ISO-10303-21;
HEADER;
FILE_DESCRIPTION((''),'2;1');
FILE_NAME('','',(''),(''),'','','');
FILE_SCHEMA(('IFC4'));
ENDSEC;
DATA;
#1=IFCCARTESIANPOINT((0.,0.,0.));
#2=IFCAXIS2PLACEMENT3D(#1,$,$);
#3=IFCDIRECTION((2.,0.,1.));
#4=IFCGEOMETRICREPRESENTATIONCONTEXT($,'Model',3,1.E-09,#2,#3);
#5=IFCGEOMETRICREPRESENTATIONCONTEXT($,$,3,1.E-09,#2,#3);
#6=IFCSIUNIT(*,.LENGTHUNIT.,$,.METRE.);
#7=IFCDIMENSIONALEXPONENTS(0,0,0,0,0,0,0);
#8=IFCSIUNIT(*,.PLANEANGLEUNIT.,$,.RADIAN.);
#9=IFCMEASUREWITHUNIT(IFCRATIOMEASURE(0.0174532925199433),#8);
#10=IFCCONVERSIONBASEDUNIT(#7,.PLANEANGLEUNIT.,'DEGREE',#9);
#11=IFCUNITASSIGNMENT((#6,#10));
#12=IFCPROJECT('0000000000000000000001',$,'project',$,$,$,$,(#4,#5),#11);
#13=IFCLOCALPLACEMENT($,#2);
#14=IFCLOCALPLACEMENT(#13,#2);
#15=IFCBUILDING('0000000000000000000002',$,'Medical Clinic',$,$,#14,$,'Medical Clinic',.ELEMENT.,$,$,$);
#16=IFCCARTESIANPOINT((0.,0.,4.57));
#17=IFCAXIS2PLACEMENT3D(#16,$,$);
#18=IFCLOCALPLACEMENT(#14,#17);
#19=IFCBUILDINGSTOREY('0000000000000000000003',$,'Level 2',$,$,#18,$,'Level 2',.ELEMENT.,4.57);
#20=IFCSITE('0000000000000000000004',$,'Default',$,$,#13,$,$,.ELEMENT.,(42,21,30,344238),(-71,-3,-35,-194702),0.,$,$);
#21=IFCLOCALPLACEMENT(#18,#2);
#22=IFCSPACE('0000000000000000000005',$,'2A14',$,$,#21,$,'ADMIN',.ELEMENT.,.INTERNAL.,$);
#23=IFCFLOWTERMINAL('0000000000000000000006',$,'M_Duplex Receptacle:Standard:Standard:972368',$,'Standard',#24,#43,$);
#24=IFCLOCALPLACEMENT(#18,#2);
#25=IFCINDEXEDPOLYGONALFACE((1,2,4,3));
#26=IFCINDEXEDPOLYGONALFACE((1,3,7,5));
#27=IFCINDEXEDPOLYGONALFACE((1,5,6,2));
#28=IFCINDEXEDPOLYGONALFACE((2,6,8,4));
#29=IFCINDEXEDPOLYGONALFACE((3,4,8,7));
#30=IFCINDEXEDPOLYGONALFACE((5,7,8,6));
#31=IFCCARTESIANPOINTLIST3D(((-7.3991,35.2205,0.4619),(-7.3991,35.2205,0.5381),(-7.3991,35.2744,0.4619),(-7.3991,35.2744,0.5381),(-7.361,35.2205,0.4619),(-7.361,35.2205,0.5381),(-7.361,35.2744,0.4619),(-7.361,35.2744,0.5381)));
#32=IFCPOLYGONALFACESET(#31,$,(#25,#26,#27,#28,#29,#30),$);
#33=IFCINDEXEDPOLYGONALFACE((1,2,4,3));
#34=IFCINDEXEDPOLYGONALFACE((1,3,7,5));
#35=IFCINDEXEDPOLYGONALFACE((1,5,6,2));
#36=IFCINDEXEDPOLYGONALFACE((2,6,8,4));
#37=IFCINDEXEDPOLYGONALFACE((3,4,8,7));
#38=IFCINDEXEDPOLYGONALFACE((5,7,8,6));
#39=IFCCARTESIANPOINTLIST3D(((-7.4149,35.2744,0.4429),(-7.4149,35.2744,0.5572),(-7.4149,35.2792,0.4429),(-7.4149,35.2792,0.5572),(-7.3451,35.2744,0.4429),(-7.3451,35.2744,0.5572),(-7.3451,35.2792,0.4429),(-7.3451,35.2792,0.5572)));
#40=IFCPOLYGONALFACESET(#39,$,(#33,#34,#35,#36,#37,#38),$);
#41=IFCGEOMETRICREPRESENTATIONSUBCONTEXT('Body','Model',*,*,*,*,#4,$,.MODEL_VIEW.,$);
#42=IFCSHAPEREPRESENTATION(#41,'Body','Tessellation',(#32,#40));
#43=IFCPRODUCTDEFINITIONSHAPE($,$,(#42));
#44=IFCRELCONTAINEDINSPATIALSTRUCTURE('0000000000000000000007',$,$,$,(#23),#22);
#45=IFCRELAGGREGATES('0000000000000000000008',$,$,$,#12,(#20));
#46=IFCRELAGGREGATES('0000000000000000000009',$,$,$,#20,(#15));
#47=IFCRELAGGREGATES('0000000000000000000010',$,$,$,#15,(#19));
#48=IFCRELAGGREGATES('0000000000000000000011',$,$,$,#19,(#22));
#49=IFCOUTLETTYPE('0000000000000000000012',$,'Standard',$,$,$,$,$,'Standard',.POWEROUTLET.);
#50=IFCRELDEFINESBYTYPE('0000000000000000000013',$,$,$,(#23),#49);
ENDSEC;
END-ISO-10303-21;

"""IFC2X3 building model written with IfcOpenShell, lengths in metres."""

from ifc_helpers import new_model, entity, si_unit, converted_unit, direction, frame, frame_2d, origin, origin_2d_with_axis, place, context, subcontext, project, spatial, rectangle, extrude, source, transform, mapped, type_object, type_shapes, element, save


model = new_model("IFC2X3")

# Units and contexts
model_context = context("Model", 3, precision=1e-09, world=origin(), true_north=direction((2.0, 0.0, 1.0)))
context_of_model = context(None, 3, precision=1e-09, world=origin(), true_north=direction((2.0, 0.0, 1.0)))
body_context = subcontext(model_context, "Body", "Model", "MODEL_VIEW")
ifc_project = project(units=[si_unit("LENGTHUNIT", "METRE"), converted_unit("PLANEANGLEUNIT", "DEGREE", entity("IfcRatioMeasure", 0.0174532925199433), si_unit("PLANEANGLEUNIT", "RADIAN"), dimensions=[0, 0, 0, 0, 0, 0, 0])], contexts=[model_context, context_of_model])

# Site, building, storey
site_placement = place(None, origin())
site = spatial("IfcSite", under=ifc_project, at=site_placement, Name="Default", CompositionType="ELEMENT", RefLatitude=(42, 21, 30, 344238), RefLongitude=(-71, -3, -35, -194702), RefElevation=0.0)
building_placement = place(site_placement, origin())
building = spatial("IfcBuilding", under=site, at=building_placement, Name="Medical Clinic", LongName="Medical Clinic", CompositionType="ELEMENT")
storey_placement = place(building_placement, frame((0.0, 0.0, 4.57)))
storey = spatial("IfcBuildingStorey", under=building, at=storey_placement, Name="Level 2", LongName="Level 2", CompositionType="ELEMENT", Elevation=4.57)

# Shared definitions
outlet_type = type_object("IfcOutletType", Name="Standard", ElementType="Standard", PredefinedType="POWEROUTLET")
shared_shape_1 = source(origin(), body_context, "Body", "SweptSolid", [
    extrude(rectangle(XDim=0.0381, YDim=0.0762, at=origin_2d_with_axis()), frame((0.0, 0.0, -0.054), z_axis=(0.0, 0.0, 1.0), x_axis=(-1.0, 0.0, 0.0)), (0.0, 0.0, 1.0), 0.054),
    extrude(rectangle(XDim=0.0698, YDim=0.1143, at=frame_2d((0.0, 0.0), x_axis=(1.0, 0.0))), frame((0.0, 0.0, 0.0), z_axis=(0.0, 0.0, 1.0), x_axis=(-1.0, 0.0, 0.0)), (0.0, 0.0, 1.0), 0.0048),
])
type_shapes(outlet_type, [shared_shape_1])

# Shared definitions
space_1_placement = place(storey_placement, origin())
space_1 = spatial("IfcSpace", under=storey, at=space_1_placement, Name="2A14", LongName="ADMIN", CompositionType="ELEMENT", InteriorOrExteriorSpace="INTERNAL")

# Flow terminal
for number, where, z_axis, x_axis, name in (
    (1, (-7.38, 35.2744, 0.5), (0.0, 1.0, 0.0), (-1.0, 0.0, 0.0), "M_Duplex Receptacle:Standard:Standard:972368"),
):
    element("IfcFlowTerminal", number, at=place(space_1_placement, frame(where, z_axis=z_axis, x_axis=x_axis)), inside=space_1, type_object=outlet_type, Name=name, ObjectType="Standard", context=body_context, shape_type="MappedRepresentation", body=[
        mapped(shared_shape_1, transform((0.0, 0.0, 0.0), scale=1.0)),
    ])

save(model, "model.ifc")
